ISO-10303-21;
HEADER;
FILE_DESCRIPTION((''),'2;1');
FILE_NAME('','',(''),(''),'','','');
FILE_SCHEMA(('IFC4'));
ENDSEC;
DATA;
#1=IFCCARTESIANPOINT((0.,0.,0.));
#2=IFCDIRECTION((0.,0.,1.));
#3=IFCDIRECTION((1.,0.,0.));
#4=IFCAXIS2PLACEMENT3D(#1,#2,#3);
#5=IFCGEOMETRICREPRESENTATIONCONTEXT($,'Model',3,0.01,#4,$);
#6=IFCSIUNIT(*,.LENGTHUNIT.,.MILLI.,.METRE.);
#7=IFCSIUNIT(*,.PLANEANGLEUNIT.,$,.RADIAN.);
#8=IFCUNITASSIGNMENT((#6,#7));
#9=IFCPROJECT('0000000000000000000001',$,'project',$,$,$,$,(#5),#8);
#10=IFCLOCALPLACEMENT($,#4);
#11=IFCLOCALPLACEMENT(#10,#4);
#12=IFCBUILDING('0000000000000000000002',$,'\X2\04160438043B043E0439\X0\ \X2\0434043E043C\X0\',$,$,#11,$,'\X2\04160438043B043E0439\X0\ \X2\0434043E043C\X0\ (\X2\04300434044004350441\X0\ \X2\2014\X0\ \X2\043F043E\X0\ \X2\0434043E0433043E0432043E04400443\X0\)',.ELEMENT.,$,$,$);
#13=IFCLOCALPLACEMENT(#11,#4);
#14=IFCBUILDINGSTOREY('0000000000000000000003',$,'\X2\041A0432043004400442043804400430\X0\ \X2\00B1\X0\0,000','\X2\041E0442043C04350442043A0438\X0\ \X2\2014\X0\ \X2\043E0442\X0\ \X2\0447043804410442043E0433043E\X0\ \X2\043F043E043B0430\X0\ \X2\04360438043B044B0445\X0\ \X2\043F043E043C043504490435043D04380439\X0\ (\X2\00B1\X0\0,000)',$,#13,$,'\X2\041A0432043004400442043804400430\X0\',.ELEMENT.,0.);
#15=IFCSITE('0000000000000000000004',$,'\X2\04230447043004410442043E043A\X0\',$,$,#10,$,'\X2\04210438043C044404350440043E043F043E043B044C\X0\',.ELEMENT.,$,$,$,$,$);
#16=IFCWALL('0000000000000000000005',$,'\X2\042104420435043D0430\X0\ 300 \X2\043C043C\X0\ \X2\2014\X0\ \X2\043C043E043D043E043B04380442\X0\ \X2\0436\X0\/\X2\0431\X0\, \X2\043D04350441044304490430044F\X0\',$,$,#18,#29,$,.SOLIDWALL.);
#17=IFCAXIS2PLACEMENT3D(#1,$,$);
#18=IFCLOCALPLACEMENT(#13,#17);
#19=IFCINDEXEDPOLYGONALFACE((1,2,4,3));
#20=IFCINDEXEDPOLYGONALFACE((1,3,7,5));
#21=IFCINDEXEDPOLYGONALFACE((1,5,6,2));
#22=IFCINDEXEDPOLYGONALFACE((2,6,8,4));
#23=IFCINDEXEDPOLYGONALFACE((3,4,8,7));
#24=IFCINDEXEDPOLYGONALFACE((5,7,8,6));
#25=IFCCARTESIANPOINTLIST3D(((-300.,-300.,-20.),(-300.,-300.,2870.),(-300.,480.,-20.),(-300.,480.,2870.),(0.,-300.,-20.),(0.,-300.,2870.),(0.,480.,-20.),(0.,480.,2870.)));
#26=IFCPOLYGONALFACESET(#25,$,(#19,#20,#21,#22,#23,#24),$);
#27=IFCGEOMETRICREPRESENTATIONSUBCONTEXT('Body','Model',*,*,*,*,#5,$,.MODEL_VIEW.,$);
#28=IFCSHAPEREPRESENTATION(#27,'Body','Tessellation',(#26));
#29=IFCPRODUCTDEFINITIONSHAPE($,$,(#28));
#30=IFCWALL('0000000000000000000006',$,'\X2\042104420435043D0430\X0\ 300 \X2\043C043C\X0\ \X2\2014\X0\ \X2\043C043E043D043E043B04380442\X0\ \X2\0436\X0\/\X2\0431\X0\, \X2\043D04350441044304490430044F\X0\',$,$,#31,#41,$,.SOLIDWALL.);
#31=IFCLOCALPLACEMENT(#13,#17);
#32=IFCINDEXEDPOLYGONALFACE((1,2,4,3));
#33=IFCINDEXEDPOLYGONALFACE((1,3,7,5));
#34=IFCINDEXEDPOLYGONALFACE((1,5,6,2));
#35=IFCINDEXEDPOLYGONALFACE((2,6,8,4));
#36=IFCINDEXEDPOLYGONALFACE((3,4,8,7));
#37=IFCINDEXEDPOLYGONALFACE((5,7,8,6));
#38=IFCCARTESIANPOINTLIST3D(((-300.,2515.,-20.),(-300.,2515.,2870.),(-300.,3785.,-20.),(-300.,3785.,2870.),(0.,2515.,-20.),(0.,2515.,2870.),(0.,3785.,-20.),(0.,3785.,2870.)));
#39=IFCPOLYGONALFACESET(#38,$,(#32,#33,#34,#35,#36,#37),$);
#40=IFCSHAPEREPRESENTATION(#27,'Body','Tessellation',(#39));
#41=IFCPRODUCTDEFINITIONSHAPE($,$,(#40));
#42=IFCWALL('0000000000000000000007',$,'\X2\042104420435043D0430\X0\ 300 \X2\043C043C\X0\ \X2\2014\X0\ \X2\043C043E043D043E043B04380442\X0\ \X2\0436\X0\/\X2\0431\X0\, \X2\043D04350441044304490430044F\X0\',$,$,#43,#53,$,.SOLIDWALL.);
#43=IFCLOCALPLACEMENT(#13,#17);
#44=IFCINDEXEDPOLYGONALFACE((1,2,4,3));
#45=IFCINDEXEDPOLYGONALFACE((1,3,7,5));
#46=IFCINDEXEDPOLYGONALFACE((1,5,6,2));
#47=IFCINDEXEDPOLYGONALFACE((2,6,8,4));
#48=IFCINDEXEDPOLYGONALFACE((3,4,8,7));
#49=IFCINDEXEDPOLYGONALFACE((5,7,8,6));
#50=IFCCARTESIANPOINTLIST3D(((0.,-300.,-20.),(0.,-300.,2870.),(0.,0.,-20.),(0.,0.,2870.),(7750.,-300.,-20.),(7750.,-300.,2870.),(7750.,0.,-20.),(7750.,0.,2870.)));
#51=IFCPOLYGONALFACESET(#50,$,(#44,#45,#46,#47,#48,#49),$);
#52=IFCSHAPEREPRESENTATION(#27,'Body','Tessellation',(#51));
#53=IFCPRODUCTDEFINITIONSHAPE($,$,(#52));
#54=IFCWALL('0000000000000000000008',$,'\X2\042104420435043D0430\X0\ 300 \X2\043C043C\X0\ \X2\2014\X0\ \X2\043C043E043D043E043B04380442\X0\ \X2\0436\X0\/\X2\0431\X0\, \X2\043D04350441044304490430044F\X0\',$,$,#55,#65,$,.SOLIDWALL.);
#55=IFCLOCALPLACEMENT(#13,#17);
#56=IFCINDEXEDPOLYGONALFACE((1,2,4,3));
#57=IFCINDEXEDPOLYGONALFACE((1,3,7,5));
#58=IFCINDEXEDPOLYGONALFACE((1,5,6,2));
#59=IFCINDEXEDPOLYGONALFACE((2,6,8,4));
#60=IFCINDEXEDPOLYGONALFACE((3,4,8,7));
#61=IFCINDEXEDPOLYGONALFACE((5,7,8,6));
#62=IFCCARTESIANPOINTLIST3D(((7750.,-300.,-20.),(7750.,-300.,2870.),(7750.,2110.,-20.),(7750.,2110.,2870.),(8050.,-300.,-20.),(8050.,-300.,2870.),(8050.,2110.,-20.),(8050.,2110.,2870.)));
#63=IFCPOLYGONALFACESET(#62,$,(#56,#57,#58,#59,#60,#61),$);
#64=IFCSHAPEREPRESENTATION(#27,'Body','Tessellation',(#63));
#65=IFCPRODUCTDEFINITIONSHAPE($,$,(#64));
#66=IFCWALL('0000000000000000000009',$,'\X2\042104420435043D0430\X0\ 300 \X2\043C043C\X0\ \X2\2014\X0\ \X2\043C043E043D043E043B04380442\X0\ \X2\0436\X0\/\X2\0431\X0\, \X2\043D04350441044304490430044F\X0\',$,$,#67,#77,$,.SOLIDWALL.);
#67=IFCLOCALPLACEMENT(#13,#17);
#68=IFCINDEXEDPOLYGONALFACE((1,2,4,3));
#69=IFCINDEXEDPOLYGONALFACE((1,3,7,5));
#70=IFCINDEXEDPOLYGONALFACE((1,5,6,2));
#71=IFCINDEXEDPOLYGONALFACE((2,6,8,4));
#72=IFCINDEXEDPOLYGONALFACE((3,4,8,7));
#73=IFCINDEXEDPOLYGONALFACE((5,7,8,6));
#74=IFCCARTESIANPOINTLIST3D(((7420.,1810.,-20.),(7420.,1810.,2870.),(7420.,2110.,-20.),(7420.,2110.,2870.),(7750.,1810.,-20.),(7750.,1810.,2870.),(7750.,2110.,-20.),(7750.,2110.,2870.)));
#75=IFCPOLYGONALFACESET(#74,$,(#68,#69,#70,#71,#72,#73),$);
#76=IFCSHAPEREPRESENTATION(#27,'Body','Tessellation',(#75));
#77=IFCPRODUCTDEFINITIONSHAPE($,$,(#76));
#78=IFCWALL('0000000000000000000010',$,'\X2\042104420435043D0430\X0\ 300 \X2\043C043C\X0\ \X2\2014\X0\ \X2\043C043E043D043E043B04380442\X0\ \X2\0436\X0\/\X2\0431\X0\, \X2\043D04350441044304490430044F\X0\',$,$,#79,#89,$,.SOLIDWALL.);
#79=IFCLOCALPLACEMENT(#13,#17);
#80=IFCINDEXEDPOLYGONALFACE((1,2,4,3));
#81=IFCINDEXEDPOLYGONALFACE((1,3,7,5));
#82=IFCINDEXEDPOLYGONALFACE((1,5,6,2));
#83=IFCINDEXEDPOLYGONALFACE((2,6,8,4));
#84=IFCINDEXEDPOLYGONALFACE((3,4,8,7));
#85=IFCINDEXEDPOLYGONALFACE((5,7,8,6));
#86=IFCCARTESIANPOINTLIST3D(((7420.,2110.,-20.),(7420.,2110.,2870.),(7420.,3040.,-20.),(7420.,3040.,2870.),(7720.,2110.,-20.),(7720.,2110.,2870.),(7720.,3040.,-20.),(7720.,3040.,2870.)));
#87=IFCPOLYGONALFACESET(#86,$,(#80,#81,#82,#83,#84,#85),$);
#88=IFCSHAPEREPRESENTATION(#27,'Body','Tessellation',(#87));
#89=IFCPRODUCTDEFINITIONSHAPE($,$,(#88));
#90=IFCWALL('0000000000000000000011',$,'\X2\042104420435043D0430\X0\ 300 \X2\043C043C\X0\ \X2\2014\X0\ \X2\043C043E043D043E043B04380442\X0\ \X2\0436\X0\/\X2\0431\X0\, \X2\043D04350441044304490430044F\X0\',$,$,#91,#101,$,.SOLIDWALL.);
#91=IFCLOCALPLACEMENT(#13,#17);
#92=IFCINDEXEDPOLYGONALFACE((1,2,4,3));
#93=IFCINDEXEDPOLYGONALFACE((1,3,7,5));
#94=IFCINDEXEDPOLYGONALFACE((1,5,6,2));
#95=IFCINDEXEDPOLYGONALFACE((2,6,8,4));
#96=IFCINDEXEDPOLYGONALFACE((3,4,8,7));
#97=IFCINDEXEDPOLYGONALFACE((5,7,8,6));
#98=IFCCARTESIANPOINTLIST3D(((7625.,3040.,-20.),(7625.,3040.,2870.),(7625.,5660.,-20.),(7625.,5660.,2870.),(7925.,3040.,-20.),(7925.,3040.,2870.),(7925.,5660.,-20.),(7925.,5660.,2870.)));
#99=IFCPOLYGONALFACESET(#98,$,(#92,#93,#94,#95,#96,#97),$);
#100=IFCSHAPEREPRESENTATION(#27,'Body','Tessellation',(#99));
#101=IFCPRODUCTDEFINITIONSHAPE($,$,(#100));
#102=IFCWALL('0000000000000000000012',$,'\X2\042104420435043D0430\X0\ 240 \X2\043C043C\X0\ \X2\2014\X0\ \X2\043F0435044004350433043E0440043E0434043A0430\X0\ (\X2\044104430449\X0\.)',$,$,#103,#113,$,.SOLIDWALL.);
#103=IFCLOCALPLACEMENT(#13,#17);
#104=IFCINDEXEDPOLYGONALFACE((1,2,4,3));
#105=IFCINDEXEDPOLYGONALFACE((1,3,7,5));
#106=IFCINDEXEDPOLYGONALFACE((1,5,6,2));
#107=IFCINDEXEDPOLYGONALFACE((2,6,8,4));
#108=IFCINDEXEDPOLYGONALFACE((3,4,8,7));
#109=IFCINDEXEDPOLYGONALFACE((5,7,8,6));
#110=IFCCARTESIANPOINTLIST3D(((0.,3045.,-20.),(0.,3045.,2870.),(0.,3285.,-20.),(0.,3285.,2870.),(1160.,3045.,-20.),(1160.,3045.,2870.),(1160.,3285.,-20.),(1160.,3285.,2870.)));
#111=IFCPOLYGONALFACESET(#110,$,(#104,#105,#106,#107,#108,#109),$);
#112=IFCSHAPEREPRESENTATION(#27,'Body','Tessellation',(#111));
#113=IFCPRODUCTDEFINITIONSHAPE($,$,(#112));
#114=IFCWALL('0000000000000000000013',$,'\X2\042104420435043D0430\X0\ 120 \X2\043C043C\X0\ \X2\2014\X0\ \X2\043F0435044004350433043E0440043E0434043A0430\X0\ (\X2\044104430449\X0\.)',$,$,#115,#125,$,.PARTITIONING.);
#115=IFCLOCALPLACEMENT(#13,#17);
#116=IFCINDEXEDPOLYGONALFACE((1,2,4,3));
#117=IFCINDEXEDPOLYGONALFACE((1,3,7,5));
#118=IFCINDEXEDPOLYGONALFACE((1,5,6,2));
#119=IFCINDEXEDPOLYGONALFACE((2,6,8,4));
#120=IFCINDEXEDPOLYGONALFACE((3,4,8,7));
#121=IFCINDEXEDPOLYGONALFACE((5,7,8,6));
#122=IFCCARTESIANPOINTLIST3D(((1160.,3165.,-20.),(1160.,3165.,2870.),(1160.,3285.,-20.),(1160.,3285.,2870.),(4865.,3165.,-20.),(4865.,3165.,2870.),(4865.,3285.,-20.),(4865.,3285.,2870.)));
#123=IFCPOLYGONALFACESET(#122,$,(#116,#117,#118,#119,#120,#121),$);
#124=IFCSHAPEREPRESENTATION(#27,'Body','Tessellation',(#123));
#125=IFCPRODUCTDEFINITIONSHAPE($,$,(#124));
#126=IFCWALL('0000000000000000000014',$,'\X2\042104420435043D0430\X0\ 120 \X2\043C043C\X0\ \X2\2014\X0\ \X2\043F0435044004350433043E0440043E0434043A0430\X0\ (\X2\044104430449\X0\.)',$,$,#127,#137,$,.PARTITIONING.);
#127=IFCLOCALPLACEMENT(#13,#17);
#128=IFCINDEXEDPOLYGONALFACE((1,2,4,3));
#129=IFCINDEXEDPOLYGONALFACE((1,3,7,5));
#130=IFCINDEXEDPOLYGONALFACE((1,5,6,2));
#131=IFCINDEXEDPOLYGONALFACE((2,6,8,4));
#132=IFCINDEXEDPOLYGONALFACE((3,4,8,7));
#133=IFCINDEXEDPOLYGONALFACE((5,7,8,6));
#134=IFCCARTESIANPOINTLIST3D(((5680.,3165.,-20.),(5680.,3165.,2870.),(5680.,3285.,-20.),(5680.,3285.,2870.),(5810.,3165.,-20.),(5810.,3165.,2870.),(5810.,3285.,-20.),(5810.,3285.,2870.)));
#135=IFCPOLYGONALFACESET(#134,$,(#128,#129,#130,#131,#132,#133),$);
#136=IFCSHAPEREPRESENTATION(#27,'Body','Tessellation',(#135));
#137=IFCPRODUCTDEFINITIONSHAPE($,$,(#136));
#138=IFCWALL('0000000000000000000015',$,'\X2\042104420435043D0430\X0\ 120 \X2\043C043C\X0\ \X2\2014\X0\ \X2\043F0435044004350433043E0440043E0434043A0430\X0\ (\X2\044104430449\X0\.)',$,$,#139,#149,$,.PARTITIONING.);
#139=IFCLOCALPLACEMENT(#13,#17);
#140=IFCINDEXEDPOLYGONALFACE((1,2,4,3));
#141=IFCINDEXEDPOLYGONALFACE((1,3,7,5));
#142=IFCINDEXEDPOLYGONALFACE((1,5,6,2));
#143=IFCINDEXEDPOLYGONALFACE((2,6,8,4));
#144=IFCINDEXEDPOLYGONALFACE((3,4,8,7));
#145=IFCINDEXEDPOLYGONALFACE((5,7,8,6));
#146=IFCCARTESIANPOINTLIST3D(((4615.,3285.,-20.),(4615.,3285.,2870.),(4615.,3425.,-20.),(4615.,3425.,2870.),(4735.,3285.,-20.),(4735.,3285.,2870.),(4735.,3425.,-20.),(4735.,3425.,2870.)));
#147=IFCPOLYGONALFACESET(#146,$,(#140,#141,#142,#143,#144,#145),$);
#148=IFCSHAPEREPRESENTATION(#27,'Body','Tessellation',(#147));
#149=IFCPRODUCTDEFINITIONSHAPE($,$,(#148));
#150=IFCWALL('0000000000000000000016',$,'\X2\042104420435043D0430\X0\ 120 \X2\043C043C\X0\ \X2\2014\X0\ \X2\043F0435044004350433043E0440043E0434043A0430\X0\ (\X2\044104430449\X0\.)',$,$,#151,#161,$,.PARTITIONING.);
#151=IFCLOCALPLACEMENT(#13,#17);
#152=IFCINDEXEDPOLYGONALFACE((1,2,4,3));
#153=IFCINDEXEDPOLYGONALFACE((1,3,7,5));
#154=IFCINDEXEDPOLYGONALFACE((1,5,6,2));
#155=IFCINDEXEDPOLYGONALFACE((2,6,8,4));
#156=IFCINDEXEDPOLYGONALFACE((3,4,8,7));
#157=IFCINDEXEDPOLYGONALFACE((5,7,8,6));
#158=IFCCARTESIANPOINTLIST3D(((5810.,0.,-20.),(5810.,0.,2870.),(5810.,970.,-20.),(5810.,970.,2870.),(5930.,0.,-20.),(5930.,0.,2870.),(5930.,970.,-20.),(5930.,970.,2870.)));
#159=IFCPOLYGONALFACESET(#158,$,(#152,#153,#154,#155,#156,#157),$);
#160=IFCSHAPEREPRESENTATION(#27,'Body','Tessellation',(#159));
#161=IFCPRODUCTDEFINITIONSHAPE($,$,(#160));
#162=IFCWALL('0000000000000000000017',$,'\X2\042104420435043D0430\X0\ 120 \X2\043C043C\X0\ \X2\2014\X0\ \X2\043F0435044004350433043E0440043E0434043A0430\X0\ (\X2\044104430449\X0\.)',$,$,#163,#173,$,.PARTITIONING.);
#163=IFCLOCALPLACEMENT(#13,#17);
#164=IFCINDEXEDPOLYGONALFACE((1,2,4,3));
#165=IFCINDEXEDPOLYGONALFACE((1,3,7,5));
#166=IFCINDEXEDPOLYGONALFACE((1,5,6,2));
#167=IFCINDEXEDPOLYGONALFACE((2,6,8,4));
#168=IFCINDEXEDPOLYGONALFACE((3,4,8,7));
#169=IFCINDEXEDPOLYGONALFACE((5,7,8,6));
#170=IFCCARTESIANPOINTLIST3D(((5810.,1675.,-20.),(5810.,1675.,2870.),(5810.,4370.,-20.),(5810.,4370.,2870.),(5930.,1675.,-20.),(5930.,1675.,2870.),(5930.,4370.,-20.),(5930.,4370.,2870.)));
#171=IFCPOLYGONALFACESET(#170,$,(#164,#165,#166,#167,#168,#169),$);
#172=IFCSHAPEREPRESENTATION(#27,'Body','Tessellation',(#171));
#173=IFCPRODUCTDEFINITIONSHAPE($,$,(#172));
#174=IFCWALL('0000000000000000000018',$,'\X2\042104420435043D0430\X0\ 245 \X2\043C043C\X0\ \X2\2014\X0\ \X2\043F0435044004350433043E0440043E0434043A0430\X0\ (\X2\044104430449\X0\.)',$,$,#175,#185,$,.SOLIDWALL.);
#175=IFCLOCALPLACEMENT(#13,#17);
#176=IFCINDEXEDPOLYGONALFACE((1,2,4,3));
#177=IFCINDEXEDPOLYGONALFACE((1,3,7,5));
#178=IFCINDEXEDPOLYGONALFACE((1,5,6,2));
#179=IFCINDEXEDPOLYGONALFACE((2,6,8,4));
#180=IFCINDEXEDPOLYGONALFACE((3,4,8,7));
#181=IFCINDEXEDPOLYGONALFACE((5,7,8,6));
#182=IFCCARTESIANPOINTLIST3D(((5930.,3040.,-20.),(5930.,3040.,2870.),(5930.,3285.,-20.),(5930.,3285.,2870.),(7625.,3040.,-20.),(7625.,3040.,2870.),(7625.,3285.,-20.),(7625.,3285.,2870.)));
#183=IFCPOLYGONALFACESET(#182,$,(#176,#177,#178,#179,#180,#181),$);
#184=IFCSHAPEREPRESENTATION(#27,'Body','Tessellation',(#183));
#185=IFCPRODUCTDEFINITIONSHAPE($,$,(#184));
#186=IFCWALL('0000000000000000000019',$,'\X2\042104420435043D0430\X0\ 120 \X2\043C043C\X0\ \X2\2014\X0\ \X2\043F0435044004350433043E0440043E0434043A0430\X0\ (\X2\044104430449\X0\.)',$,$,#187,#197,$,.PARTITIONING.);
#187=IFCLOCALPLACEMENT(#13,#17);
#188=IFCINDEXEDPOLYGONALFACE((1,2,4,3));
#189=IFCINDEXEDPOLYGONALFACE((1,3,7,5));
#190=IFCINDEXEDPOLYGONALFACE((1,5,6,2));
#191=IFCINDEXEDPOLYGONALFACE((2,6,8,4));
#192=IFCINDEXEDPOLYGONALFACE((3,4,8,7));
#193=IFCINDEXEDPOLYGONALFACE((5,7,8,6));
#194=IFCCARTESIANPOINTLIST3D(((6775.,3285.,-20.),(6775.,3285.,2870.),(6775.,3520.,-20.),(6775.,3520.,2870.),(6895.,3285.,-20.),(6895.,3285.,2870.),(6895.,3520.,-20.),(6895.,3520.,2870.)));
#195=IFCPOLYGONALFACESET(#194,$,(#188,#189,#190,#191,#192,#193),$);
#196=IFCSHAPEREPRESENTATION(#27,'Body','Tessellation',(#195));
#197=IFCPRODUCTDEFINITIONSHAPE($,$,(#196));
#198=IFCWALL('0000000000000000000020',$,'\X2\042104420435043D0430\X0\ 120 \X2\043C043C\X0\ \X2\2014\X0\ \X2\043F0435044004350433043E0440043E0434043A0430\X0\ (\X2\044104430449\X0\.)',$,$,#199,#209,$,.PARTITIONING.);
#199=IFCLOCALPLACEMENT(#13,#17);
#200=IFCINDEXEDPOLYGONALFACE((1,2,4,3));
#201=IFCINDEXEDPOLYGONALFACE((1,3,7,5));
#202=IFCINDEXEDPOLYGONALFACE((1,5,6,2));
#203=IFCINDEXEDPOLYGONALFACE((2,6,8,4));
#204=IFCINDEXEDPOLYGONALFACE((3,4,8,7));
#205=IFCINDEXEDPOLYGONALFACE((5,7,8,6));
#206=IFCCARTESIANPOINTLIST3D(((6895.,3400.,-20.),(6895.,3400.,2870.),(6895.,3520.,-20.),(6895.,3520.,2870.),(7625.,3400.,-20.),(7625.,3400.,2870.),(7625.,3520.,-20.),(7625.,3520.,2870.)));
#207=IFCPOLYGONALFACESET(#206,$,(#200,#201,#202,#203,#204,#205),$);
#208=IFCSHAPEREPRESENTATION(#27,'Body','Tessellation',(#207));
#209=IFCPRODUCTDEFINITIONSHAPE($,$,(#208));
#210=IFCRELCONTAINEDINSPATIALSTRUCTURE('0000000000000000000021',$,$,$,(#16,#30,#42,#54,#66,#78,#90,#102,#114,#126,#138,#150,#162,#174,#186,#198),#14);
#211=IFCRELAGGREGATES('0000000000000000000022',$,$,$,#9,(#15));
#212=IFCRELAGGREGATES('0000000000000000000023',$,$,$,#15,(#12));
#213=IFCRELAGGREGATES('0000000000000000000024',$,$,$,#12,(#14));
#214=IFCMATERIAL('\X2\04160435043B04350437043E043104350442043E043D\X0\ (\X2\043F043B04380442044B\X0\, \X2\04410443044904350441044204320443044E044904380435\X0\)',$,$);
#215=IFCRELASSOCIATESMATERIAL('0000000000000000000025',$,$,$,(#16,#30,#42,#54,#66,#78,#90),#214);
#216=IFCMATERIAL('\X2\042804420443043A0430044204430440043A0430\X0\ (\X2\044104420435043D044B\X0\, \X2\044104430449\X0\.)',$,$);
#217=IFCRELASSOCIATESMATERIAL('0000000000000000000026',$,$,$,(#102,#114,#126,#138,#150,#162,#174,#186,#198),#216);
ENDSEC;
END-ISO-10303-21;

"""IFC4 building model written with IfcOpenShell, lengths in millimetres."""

from ifc_helpers import new_model, si_unit, frame, origin, origin_with_axes, place, context, subcontext, project, spatial, polyline, outline, extrude, material, element, save


model = new_model("IFC4")

# Units and contexts
model_context = context("Model", 3, precision=0.01, world=origin_with_axes())
body_context = subcontext(model_context, "Body", "Model", "MODEL_VIEW")
ifc_project = project(units=[si_unit("LENGTHUNIT", "METRE", prefix="MILLI"), si_unit("PLANEANGLEUNIT", "RADIAN")], contexts=[model_context])

# Site, building, storey
site_placement = place(None, origin_with_axes())
site = spatial("IfcSite", under=ifc_project, at=site_placement, Name="Участок", LongName="Симферополь", CompositionType="ELEMENT")
building_placement = place(site_placement, origin_with_axes())
building = spatial("IfcBuilding", under=site, at=building_placement, Name="Жилой дом", LongName="Жилой дом (адрес — по договору)", CompositionType="ELEMENT")
storey_placement = place(building_placement, origin_with_axes())
storey = spatial("IfcBuildingStorey", under=building, at=storey_placement, Name="Квартира ±0,000", Description="Отметки — от чистого пола жилых помещений (±0,000)", LongName="Квартира", CompositionType="ELEMENT", Elevation=0.0)

# Shared definitions
ifc_material_1 = material(Name="Железобетон (плиты, существующие)")

# Walls
wall_1_placement = place(storey_placement, frame((-300.0, -300.0, -20.0)))
element("IfcWall", 1, at=wall_1_placement, inside=storey, material=ifc_material_1, Name="Стена 300 мм — монолит ж/б, несущая", PredefinedType="SOLIDWALL", context=body_context, shape_type="SweptSolid", body=[
    extrude(outline(polyline([(0.0, 0.0), (300.0, 0.0), (300.0, 780.0), (0.0, 780.0), (0.0, 0.0)])), origin(), (0.0, 0.0, 1.0), 2890.0),
])
wall_2_placement = place(storey_placement, frame((-300.0, 2515.0, -20.0)))
element("IfcWall", 2, at=wall_2_placement, inside=storey, material=ifc_material_1, Name="Стена 300 мм — монолит ж/б, несущая", PredefinedType="SOLIDWALL", context=body_context, shape_type="SweptSolid", body=[
    extrude(outline(polyline([(0.0, 0.0), (300.0, 0.0), (300.0, 1270.0), (0.0, 1270.0), (0.0, 0.0)])), origin(), (0.0, 0.0, 1.0), 2890.0),
])
wall_3_placement = place(storey_placement, frame((0.0, -300.0, -20.0)))
element("IfcWall", 3, at=wall_3_placement, inside=storey, material=ifc_material_1, Name="Стена 300 мм — монолит ж/б, несущая", PredefinedType="SOLIDWALL", context=body_context, shape_type="SweptSolid", body=[
    extrude(outline(polyline([(0.0, 0.0), (7750.0, 0.0), (7750.0, 300.0), (0.0, 300.0), (0.0, 0.0)])), origin(), (0.0, 0.0, 1.0), 2890.0),
])
wall_4_placement = place(storey_placement, frame((7750.0, -300.0, -20.0)))
element("IfcWall", 4, at=wall_4_placement, inside=storey, material=ifc_material_1, Name="Стена 300 мм — монолит ж/б, несущая", PredefinedType="SOLIDWALL", context=body_context, shape_type="SweptSolid", body=[
    extrude(outline(polyline([(0.0, 0.0), (300.0, 0.0), (300.0, 2410.0), (0.0, 2410.0), (0.0, 0.0)])), origin(), (0.0, 0.0, 1.0), 2890.0),
])
wall_5_placement = place(storey_placement, frame((7420.0, 1810.0, -20.0)))
element("IfcWall", 5, at=wall_5_placement, inside=storey, material=ifc_material_1, Name="Стена 300 мм — монолит ж/б, несущая", PredefinedType="SOLIDWALL", context=body_context, shape_type="SweptSolid", body=[
    extrude(outline(polyline([(0.0, 0.0), (330.0, 0.0), (330.0, 300.0), (0.0, 300.0), (0.0, 0.0)])), origin(), (0.0, 0.0, 1.0), 2890.0),
])
wall_6_placement = place(storey_placement, frame((7420.0, 2110.0, -20.0)))
element("IfcWall", 6, at=wall_6_placement, inside=storey, material=ifc_material_1, Name="Стена 300 мм — монолит ж/б, несущая", PredefinedType="SOLIDWALL", context=body_context, shape_type="SweptSolid", body=[
    extrude(outline(polyline([(0.0, 0.0), (300.0, 0.0), (300.0, 930.0), (0.0, 930.0), (0.0, 0.0)])), origin(), (0.0, 0.0, 1.0), 2890.0),
])
wall_7_placement = place(storey_placement, frame((7625.0, 3040.0, -20.0)))
element("IfcWall", 7, at=wall_7_placement, inside=storey, material=ifc_material_1, Name="Стена 300 мм — монолит ж/б, несущая", PredefinedType="SOLIDWALL", context=body_context, shape_type="SweptSolid", body=[
    extrude(outline(polyline([(0.0, 0.0), (300.0, 0.0), (300.0, 2620.0), (0.0, 2620.0), (0.0, 0.0)])), origin(), (0.0, 0.0, 1.0), 2890.0),
])
ifc_material_2 = material(Name="Штукатурка (стены, сущ.)")
wall_8_placement = place(storey_placement, frame((0.0, 3045.0, -20.0)))
element("IfcWall", 8, at=wall_8_placement, inside=storey, material=ifc_material_2, Name="Стена 240 мм — перегородка (сущ.)", PredefinedType="SOLIDWALL", context=body_context, shape_type="SweptSolid", body=[
    extrude(outline(polyline([(0.0, 0.0), (1160.0, 0.0), (1160.0, 240.0), (0.0, 240.0), (0.0, 0.0)])), origin(), (0.0, 0.0, 1.0), 2890.0),
])
wall_9_placement = place(storey_placement, frame((1160.0, 3165.0, -20.0)))
element("IfcWall", 9, at=wall_9_placement, inside=storey, material=ifc_material_2, Name="Стена 120 мм — перегородка (сущ.)", PredefinedType="PARTITIONING", context=body_context, shape_type="SweptSolid", body=[
    extrude(outline(polyline([(0.0, 0.0), (3705.0, 0.0), (3705.0, 120.0), (0.0, 120.0), (0.0, 0.0)])), origin(), (0.0, 0.0, 1.0), 2890.0),
])
wall_10_placement = place(storey_placement, frame((5680.0, 3165.0, -20.0)))
element("IfcWall", 10, at=wall_10_placement, inside=storey, material=ifc_material_2, Name="Стена 120 мм — перегородка (сущ.)", PredefinedType="PARTITIONING", context=body_context, shape_type="SweptSolid", body=[
    extrude(outline(polyline([(0.0, 0.0), (130.0, 0.0), (130.0, 120.0), (0.0, 120.0), (0.0, 0.0)])), origin(), (0.0, 0.0, 1.0), 2890.0),
])
wall_11_placement = place(storey_placement, frame((4615.0, 3285.0, -20.0)))
element("IfcWall", 11, at=wall_11_placement, inside=storey, material=ifc_material_2, Name="Стена 120 мм — перегородка (сущ.)", PredefinedType="PARTITIONING", context=body_context, shape_type="SweptSolid", body=[
    extrude(outline(polyline([(0.0, 0.0), (120.0, 0.0), (120.0, 140.0), (0.0, 140.0), (0.0, 0.0)])), origin(), (0.0, 0.0, 1.0), 2890.0),
])
wall_12_placement = place(storey_placement, frame((5810.0, 0.0, -20.0)))
element("IfcWall", 12, at=wall_12_placement, inside=storey, material=ifc_material_2, Name="Стена 120 мм — перегородка (сущ.)", PredefinedType="PARTITIONING", context=body_context, shape_type="SweptSolid", body=[
    extrude(outline(polyline([(0.0, 0.0), (120.0, 0.0), (120.0, 970.0), (0.0, 970.0), (0.0, 0.0)])), origin(), (0.0, 0.0, 1.0), 2890.0),
])
wall_13_placement = place(storey_placement, frame((5810.0, 1675.0, -20.0)))
element("IfcWall", 13, at=wall_13_placement, inside=storey, material=ifc_material_2, Name="Стена 120 мм — перегородка (сущ.)", PredefinedType="PARTITIONING", context=body_context, shape_type="SweptSolid", body=[
    extrude(outline(polyline([(0.0, 0.0), (120.0, 0.0), (120.0, 2695.0), (0.0, 2695.0), (0.0, 0.0)])), origin(), (0.0, 0.0, 1.0), 2890.0),
])
wall_14_placement = place(storey_placement, frame((5930.0, 3040.0, -20.0)))
element("IfcWall", 14, at=wall_14_placement, inside=storey, material=ifc_material_2, Name="Стена 245 мм — перегородка (сущ.)", PredefinedType="SOLIDWALL", context=body_context, shape_type="SweptSolid", body=[
    extrude(outline(polyline([(0.0, 0.0), (1695.0, 0.0), (1695.0, 245.0), (0.0, 245.0), (0.0, 0.0)])), origin(), (0.0, 0.0, 1.0), 2890.0),
])
wall_15_placement = place(storey_placement, frame((6775.0, 3285.0, -20.0)))
element("IfcWall", 15, at=wall_15_placement, inside=storey, material=ifc_material_2, Name="Стена 120 мм — перегородка (сущ.)", PredefinedType="PARTITIONING", context=body_context, shape_type="SweptSolid", body=[
    extrude(outline(polyline([(0.0, 0.0), (120.0, 0.0), (120.0, 235.0), (0.0, 235.0), (0.0, 0.0)])), origin(), (0.0, 0.0, 1.0), 2890.0),
])
wall_16_placement = place(storey_placement, frame((6895.0, 3400.0, -20.0)))
element("IfcWall", 16, at=wall_16_placement, inside=storey, material=ifc_material_2, Name="Стена 120 мм — перегородка (сущ.)", PredefinedType="PARTITIONING", context=body_context, shape_type="SweptSolid", body=[
    extrude(outline(polyline([(0.0, 0.0), (730.0, 0.0), (730.0, 120.0), (0.0, 120.0), (0.0, 0.0)])), origin(), (0.0, 0.0, 1.0), 2890.0),
])

save(model, "model.ifc")
